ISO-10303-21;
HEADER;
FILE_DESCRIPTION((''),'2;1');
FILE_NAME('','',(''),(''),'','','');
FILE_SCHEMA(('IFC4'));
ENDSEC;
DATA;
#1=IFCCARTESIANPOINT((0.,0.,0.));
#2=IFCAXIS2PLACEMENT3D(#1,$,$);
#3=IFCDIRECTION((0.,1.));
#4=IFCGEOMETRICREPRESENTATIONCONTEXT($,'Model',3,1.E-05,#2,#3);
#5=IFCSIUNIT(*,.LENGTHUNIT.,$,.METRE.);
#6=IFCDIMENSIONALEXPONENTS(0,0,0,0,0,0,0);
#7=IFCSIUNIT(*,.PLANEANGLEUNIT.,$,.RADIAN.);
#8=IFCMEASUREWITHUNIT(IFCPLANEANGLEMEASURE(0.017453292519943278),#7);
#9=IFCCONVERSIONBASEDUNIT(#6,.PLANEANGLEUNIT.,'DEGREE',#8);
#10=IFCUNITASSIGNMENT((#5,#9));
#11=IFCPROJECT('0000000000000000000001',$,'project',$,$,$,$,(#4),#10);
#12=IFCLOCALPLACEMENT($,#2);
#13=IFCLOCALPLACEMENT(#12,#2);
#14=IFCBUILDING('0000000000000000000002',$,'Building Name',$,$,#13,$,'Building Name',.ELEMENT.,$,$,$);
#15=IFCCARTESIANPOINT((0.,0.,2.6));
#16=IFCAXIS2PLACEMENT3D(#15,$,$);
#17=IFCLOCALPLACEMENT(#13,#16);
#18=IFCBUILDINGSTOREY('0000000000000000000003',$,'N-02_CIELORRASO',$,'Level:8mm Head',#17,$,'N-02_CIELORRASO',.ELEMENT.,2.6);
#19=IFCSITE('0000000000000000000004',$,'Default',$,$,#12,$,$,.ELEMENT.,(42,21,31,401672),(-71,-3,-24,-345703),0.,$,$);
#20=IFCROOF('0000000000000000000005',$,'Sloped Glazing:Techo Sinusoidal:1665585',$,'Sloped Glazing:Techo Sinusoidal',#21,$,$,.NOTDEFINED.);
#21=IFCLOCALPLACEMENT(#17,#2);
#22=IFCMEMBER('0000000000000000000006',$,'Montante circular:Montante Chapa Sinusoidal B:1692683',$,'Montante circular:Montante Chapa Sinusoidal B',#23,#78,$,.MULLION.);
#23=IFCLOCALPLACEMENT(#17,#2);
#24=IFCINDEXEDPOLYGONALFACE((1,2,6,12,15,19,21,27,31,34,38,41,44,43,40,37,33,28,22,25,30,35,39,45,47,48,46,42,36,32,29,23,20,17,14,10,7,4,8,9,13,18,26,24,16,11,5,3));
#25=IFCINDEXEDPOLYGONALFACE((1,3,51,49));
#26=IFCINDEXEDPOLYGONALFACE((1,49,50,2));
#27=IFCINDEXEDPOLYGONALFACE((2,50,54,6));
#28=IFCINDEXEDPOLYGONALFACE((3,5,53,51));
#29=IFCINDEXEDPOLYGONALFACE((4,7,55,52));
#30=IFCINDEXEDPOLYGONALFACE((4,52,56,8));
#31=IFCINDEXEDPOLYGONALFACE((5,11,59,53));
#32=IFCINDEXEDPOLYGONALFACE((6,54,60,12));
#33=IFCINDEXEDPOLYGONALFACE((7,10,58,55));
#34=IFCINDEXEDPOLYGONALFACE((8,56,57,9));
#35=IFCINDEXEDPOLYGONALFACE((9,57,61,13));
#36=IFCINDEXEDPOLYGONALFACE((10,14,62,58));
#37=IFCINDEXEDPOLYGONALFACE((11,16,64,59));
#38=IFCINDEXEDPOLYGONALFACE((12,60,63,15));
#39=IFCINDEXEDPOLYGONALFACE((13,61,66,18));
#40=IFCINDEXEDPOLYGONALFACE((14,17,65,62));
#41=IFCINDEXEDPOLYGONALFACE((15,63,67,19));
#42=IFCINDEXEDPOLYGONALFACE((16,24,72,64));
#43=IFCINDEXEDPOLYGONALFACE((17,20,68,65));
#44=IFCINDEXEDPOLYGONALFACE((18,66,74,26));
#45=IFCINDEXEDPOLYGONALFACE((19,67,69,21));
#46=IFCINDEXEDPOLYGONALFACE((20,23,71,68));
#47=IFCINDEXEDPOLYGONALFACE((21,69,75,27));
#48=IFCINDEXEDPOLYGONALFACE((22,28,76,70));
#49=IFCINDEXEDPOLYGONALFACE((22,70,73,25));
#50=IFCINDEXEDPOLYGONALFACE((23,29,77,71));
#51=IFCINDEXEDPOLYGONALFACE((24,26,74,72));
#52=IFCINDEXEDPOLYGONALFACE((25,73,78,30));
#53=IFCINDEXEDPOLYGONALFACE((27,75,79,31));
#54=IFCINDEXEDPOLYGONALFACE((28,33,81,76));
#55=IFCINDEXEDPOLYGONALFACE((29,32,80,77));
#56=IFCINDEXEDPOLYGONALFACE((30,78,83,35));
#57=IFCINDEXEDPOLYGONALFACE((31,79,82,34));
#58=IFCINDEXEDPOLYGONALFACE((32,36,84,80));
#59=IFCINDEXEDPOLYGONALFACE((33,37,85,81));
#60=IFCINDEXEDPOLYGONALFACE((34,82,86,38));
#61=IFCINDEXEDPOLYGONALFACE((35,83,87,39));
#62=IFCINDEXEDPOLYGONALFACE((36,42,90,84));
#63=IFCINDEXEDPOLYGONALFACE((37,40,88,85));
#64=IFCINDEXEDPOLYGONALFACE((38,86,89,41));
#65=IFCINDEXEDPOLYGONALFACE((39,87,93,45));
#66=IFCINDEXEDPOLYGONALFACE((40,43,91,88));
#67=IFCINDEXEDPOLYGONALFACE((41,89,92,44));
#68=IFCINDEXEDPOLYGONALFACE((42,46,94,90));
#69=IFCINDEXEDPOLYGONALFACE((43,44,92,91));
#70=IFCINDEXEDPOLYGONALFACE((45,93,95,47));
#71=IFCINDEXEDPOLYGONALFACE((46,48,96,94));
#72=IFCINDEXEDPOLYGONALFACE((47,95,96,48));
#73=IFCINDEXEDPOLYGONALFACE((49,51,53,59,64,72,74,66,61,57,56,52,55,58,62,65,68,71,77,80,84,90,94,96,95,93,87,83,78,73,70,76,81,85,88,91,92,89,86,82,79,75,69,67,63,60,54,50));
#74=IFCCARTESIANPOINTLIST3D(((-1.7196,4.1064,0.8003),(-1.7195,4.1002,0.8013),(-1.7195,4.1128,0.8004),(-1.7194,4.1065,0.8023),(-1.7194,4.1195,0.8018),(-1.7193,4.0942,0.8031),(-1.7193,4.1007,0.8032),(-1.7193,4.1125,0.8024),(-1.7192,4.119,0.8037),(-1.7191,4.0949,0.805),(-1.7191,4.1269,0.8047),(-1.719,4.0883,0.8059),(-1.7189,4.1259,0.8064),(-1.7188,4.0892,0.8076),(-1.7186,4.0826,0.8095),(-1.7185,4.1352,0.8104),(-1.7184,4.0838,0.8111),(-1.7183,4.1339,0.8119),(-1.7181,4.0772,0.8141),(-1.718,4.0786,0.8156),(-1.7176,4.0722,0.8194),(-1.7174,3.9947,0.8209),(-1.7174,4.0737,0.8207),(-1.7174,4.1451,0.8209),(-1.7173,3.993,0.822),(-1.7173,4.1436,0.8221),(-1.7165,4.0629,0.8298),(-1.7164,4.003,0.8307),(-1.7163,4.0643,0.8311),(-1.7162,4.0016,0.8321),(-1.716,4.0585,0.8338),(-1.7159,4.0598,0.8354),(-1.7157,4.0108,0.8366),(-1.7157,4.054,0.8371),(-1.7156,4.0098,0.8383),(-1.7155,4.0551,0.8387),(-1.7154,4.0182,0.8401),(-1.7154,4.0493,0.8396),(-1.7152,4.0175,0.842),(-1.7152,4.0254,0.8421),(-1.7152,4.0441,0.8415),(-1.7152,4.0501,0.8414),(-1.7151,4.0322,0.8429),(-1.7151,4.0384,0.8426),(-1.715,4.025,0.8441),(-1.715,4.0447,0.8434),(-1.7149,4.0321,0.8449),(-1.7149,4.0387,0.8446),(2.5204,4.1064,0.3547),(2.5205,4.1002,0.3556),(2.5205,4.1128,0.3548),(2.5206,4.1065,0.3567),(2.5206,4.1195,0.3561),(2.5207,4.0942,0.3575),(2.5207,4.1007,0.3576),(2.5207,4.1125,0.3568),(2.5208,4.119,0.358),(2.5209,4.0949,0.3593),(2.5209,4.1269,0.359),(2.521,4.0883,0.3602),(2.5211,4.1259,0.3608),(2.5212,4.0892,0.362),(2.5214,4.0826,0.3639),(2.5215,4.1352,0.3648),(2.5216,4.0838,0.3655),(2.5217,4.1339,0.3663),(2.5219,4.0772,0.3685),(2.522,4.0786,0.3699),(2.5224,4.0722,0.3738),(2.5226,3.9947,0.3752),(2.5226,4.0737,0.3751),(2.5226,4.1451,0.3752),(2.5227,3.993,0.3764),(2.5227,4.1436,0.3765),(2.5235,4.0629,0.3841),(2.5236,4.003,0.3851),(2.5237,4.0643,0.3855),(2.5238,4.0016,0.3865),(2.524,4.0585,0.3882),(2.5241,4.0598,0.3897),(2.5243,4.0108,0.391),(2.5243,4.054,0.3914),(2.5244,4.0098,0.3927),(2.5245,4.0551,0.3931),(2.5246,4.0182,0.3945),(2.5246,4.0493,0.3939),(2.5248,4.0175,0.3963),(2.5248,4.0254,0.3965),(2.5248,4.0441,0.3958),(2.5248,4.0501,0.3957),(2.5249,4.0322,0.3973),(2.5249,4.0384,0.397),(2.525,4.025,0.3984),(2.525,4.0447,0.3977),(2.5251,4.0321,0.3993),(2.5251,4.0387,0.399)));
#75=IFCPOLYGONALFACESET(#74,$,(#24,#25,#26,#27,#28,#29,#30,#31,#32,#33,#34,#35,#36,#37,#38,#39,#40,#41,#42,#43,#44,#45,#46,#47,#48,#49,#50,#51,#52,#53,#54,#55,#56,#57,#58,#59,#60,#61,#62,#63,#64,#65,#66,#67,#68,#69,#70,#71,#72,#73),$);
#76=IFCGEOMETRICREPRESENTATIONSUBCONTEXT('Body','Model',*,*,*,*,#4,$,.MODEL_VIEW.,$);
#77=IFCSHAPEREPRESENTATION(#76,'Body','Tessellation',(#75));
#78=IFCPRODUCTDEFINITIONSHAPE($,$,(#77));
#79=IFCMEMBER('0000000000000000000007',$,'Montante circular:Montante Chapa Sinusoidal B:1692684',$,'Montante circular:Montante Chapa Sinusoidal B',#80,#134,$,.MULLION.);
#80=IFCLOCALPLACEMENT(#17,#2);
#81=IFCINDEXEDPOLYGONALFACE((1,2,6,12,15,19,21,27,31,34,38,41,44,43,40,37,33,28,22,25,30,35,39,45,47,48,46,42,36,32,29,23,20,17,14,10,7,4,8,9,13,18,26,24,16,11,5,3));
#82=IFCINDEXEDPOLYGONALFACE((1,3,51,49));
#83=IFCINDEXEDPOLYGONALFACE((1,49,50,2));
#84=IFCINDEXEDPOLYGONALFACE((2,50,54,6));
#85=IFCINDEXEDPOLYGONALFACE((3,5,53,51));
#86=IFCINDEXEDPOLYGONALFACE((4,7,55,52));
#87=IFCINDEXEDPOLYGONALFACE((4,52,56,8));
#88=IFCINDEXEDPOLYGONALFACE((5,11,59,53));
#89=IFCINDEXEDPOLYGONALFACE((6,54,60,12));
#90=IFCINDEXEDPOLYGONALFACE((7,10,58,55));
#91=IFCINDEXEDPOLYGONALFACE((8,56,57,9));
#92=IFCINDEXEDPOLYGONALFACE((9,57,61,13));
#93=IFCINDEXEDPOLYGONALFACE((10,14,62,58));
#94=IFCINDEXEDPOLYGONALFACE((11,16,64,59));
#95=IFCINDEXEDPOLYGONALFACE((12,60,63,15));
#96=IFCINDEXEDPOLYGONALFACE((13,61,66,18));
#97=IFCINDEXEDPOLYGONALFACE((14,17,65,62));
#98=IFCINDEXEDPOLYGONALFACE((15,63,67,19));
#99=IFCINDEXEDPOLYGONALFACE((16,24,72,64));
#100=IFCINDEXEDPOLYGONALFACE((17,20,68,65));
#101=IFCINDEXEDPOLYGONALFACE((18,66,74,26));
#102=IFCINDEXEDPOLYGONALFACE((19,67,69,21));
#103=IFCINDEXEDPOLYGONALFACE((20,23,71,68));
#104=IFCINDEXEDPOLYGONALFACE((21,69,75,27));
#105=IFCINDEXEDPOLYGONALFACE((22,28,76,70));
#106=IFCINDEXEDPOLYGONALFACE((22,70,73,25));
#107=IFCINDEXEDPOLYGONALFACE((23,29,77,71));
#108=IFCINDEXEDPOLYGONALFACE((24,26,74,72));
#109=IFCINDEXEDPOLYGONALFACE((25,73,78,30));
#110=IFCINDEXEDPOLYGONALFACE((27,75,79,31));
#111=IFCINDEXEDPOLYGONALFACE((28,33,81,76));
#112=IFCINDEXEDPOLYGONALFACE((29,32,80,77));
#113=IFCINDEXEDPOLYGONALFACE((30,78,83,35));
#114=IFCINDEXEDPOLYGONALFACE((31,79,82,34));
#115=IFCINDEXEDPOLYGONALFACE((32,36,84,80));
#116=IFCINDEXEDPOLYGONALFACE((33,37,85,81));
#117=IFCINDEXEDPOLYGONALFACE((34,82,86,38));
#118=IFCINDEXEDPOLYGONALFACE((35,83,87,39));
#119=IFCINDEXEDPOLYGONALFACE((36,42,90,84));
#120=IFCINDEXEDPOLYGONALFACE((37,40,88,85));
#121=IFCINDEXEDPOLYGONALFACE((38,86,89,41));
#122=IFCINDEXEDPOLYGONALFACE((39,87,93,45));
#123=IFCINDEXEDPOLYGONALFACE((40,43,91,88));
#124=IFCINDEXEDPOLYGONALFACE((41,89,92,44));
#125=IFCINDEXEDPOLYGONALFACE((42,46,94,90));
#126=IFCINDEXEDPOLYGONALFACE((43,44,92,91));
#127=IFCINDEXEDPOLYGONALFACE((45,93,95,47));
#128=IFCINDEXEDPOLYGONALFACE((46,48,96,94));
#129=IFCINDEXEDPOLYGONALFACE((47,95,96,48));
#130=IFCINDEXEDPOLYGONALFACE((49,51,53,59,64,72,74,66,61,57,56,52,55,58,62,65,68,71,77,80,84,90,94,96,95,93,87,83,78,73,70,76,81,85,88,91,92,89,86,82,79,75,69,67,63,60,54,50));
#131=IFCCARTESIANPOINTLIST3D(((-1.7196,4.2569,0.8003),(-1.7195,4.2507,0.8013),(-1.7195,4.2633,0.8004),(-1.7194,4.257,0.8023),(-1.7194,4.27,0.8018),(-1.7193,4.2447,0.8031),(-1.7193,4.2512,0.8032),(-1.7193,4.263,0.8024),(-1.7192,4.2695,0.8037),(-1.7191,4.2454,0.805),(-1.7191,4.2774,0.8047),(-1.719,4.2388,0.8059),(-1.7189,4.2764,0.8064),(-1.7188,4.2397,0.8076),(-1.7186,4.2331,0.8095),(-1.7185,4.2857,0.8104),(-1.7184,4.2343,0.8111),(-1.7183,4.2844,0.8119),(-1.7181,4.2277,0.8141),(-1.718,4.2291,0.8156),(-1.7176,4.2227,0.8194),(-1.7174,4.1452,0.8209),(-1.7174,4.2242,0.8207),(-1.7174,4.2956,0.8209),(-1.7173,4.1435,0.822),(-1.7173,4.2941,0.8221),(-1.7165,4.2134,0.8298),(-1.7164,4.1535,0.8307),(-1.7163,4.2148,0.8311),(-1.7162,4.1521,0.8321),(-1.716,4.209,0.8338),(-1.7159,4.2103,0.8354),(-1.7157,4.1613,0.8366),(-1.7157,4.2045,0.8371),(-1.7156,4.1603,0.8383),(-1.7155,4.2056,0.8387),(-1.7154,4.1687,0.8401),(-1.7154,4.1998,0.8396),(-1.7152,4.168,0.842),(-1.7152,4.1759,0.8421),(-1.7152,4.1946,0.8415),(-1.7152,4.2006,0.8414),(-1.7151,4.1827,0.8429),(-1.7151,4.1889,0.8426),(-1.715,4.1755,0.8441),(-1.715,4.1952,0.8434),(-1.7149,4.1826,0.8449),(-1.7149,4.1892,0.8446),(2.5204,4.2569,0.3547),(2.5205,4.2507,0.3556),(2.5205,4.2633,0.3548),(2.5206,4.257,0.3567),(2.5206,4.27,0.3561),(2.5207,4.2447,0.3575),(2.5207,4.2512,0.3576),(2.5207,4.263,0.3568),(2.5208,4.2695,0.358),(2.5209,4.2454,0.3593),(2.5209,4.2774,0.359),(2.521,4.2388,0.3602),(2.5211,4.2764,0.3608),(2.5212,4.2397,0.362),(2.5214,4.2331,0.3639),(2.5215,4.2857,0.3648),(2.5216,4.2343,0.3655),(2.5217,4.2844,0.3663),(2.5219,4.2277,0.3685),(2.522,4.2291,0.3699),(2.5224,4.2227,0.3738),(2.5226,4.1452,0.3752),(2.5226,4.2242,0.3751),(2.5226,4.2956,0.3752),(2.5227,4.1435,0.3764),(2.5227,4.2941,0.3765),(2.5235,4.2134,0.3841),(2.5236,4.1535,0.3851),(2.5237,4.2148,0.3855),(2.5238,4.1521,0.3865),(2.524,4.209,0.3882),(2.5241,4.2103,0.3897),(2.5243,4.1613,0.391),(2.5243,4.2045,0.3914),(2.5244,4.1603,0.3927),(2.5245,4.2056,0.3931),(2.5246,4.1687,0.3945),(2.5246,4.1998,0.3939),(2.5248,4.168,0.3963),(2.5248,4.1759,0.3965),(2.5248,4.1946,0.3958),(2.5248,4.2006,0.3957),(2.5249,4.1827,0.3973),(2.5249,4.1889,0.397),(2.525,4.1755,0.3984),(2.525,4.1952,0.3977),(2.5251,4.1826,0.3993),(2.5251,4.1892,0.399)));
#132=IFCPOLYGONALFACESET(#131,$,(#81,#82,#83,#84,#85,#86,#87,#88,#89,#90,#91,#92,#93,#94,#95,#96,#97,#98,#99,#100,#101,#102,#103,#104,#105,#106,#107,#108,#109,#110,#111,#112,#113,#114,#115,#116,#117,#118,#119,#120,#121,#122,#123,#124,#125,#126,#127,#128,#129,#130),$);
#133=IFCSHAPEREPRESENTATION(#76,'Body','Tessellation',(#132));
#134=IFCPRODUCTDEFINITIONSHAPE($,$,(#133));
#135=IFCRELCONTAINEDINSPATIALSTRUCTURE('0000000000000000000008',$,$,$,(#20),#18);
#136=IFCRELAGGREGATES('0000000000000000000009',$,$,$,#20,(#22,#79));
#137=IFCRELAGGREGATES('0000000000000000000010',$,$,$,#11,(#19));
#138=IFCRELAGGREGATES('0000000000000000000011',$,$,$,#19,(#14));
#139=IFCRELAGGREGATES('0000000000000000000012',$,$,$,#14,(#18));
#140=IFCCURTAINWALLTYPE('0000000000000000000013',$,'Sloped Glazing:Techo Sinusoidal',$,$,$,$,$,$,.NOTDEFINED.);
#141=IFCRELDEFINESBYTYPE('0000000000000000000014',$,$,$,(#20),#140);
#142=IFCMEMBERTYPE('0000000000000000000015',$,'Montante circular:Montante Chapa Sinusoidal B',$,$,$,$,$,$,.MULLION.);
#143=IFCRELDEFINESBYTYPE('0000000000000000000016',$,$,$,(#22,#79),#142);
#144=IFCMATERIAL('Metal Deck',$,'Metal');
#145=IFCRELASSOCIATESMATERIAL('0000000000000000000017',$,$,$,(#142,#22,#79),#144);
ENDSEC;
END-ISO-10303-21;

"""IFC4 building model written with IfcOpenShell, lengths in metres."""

from ifc_helpers import new_model, entity, si_unit, converted_unit, direction, frame, origin, place, context, subcontext, project, spatial, indexed_curve, outline, extrude, source, transform, mapped, material, type_object, type_shapes, element, aggregate, save


model = new_model("IFC4")

# Units and contexts
model_context = context("Model", 3, precision=1e-05, world=origin(), true_north=direction((0.0, 1.0)))
body_context = subcontext(model_context, "Body", "Model", "MODEL_VIEW")
ifc_project = project(units=[si_unit("LENGTHUNIT", "METRE"), converted_unit("PLANEANGLEUNIT", "DEGREE", entity("IfcPlaneAngleMeasure", 0.017453292519943278), si_unit("PLANEANGLEUNIT", "RADIAN"), dimensions=[0, 0, 0, 0, 0, 0, 0])], contexts=[model_context])

# Site, building, storey
site_placement = place(None, origin())
site = spatial("IfcSite", under=ifc_project, at=site_placement, Name="Default", CompositionType="ELEMENT", RefLatitude=(42, 21, 31, 401672), RefLongitude=(-71, -3, -24, -345703), RefElevation=0.0)
building_placement = place(site_placement, origin())
building = spatial("IfcBuilding", under=site, at=building_placement, Name="Building Name", LongName="Building Name", CompositionType="ELEMENT")
storey_placement = place(building_placement, frame((0.0, 0.0, 2.6)))
storey = spatial("IfcBuildingStorey", under=building, at=storey_placement, Name="N-02_CIELORRASO", ObjectType="Level:8mm Head", LongName="N-02_CIELORRASO", CompositionType="ELEMENT", Elevation=2.6)

# Roof, members
curtain_wall_type = type_object("IfcCurtainWallType", Name="Sloped Glazing:Techo Sinusoidal", PredefinedType="NOTDEFINED")
roof_placement = place(storey_placement, frame((0.0, 0.0, -2.6)))
roof = element("IfcRoof", 1, at=roof_placement, inside=storey, type_object=curtain_wall_type, Name="Sloped Glazing:Techo Sinusoidal:1665585", ObjectType="Sloped Glazing:Techo Sinusoidal", PredefinedType="NOTDEFINED")
ifc_material = material(Name="Metal Deck", Category="Metal")
member_type = type_object("IfcMemberType", Name="Montante circular:Montante Chapa Sinusoidal B", PredefinedType="MULLION", material=ifc_material)
shared_shape = source(origin(), body_context, "Body", "SweptSolid", [
    extrude(outline(indexed_curve([(0.0595, -0.0443), (0.0615, -0.0443), (0.0603, -0.031), (0.0572, -0.0213), (0.053, -0.0138), (0.0481, -0.0078), (0.0427, -0.003), (0.0372, 0.0005), (0.0315, 0.0029), (0.0259, 0.0044), (0.0203, 0.0051), (0.0146, 0.005), (0.0084, 0.0041), (-0.0053, 0.0009), (-0.0123, -0.0005), (-0.0191, -0.0012), (-0.0256, -0.001), (-0.0317, 0.0001), (-0.0375, 0.0019), (-0.0428, 0.0046), (-0.0477, 0.0081), (-0.0522, 0.0128), (-0.0563, 0.0191), (-0.0597, 0.0282), (-0.0617, 0.0421), (-0.0637, 0.042), (-0.0616, 0.0277), (-0.0581, 0.0182), (-0.0537, 0.0116), (-0.049, 0.0066), (-0.0438, 0.0028), (-0.0382, 0.0001), (-0.0322, -0.0019), (-0.0258, -0.003), (-0.019, -0.0032), (-0.012, -0.0025), (-0.0048, -0.0011), (0.0088, 0.0021), (0.0147, 0.003), (0.0202, 0.0031), (0.0255, 0.0024), (0.0309, 0.001), (0.0362, -0.0013), (0.0415, -0.0046), (0.0466, -0.0092), (0.0513, -0.0149), (0.0554, -0.0221), (0.0584, -0.0314), (0.0595, -0.0443)], self_intersect=False)), frame((-0.007, 0.0228, -4.2634), z_axis=(0.0, 0.0, 1.0), x_axis=(-0.819152, -0.573576, 0.0)), (0.0, 0.0, 1.0), 4.2634),
])
type_shapes(member_type, [shared_shape])
member_1_placement = place(roof_placement, frame((-1.7148, 4.0759, 3.4456), z_axis=(-0.994522, 0.0, 0.104528), x_axis=(0.0, 1.0, 0.0)))
member_1 = element("IfcMember", 2, at=member_1_placement, type_object=member_type, material=ifc_material, Name="Montante circular:Montante Chapa Sinusoidal B:1692683", ObjectType="Montante circular:Montante Chapa Sinusoidal B", PredefinedType="MULLION", context=body_context, shape_type="MappedRepresentation", body=[
    mapped(shared_shape, transform((0.0, 0.0, 0.0), scale=1.0)),
])
member_2_placement = place(roof_placement, frame((-1.7148, 4.2264, 3.4456), z_axis=(-0.994522, 0.0, 0.104528), x_axis=(0.0, 1.0, 0.0)))
member_2 = element("IfcMember", 3, at=member_2_placement, type_object=member_type, material=ifc_material, Name="Montante circular:Montante Chapa Sinusoidal B:1692684", ObjectType="Montante circular:Montante Chapa Sinusoidal B", PredefinedType="MULLION", context=body_context, shape_type="MappedRepresentation", body=[
    mapped(shared_shape, transform((0.0, 0.0, 0.0), scale=1.0)),
])
aggregate(roof, [member_1, member_2])

save(model, "model.ifc")
